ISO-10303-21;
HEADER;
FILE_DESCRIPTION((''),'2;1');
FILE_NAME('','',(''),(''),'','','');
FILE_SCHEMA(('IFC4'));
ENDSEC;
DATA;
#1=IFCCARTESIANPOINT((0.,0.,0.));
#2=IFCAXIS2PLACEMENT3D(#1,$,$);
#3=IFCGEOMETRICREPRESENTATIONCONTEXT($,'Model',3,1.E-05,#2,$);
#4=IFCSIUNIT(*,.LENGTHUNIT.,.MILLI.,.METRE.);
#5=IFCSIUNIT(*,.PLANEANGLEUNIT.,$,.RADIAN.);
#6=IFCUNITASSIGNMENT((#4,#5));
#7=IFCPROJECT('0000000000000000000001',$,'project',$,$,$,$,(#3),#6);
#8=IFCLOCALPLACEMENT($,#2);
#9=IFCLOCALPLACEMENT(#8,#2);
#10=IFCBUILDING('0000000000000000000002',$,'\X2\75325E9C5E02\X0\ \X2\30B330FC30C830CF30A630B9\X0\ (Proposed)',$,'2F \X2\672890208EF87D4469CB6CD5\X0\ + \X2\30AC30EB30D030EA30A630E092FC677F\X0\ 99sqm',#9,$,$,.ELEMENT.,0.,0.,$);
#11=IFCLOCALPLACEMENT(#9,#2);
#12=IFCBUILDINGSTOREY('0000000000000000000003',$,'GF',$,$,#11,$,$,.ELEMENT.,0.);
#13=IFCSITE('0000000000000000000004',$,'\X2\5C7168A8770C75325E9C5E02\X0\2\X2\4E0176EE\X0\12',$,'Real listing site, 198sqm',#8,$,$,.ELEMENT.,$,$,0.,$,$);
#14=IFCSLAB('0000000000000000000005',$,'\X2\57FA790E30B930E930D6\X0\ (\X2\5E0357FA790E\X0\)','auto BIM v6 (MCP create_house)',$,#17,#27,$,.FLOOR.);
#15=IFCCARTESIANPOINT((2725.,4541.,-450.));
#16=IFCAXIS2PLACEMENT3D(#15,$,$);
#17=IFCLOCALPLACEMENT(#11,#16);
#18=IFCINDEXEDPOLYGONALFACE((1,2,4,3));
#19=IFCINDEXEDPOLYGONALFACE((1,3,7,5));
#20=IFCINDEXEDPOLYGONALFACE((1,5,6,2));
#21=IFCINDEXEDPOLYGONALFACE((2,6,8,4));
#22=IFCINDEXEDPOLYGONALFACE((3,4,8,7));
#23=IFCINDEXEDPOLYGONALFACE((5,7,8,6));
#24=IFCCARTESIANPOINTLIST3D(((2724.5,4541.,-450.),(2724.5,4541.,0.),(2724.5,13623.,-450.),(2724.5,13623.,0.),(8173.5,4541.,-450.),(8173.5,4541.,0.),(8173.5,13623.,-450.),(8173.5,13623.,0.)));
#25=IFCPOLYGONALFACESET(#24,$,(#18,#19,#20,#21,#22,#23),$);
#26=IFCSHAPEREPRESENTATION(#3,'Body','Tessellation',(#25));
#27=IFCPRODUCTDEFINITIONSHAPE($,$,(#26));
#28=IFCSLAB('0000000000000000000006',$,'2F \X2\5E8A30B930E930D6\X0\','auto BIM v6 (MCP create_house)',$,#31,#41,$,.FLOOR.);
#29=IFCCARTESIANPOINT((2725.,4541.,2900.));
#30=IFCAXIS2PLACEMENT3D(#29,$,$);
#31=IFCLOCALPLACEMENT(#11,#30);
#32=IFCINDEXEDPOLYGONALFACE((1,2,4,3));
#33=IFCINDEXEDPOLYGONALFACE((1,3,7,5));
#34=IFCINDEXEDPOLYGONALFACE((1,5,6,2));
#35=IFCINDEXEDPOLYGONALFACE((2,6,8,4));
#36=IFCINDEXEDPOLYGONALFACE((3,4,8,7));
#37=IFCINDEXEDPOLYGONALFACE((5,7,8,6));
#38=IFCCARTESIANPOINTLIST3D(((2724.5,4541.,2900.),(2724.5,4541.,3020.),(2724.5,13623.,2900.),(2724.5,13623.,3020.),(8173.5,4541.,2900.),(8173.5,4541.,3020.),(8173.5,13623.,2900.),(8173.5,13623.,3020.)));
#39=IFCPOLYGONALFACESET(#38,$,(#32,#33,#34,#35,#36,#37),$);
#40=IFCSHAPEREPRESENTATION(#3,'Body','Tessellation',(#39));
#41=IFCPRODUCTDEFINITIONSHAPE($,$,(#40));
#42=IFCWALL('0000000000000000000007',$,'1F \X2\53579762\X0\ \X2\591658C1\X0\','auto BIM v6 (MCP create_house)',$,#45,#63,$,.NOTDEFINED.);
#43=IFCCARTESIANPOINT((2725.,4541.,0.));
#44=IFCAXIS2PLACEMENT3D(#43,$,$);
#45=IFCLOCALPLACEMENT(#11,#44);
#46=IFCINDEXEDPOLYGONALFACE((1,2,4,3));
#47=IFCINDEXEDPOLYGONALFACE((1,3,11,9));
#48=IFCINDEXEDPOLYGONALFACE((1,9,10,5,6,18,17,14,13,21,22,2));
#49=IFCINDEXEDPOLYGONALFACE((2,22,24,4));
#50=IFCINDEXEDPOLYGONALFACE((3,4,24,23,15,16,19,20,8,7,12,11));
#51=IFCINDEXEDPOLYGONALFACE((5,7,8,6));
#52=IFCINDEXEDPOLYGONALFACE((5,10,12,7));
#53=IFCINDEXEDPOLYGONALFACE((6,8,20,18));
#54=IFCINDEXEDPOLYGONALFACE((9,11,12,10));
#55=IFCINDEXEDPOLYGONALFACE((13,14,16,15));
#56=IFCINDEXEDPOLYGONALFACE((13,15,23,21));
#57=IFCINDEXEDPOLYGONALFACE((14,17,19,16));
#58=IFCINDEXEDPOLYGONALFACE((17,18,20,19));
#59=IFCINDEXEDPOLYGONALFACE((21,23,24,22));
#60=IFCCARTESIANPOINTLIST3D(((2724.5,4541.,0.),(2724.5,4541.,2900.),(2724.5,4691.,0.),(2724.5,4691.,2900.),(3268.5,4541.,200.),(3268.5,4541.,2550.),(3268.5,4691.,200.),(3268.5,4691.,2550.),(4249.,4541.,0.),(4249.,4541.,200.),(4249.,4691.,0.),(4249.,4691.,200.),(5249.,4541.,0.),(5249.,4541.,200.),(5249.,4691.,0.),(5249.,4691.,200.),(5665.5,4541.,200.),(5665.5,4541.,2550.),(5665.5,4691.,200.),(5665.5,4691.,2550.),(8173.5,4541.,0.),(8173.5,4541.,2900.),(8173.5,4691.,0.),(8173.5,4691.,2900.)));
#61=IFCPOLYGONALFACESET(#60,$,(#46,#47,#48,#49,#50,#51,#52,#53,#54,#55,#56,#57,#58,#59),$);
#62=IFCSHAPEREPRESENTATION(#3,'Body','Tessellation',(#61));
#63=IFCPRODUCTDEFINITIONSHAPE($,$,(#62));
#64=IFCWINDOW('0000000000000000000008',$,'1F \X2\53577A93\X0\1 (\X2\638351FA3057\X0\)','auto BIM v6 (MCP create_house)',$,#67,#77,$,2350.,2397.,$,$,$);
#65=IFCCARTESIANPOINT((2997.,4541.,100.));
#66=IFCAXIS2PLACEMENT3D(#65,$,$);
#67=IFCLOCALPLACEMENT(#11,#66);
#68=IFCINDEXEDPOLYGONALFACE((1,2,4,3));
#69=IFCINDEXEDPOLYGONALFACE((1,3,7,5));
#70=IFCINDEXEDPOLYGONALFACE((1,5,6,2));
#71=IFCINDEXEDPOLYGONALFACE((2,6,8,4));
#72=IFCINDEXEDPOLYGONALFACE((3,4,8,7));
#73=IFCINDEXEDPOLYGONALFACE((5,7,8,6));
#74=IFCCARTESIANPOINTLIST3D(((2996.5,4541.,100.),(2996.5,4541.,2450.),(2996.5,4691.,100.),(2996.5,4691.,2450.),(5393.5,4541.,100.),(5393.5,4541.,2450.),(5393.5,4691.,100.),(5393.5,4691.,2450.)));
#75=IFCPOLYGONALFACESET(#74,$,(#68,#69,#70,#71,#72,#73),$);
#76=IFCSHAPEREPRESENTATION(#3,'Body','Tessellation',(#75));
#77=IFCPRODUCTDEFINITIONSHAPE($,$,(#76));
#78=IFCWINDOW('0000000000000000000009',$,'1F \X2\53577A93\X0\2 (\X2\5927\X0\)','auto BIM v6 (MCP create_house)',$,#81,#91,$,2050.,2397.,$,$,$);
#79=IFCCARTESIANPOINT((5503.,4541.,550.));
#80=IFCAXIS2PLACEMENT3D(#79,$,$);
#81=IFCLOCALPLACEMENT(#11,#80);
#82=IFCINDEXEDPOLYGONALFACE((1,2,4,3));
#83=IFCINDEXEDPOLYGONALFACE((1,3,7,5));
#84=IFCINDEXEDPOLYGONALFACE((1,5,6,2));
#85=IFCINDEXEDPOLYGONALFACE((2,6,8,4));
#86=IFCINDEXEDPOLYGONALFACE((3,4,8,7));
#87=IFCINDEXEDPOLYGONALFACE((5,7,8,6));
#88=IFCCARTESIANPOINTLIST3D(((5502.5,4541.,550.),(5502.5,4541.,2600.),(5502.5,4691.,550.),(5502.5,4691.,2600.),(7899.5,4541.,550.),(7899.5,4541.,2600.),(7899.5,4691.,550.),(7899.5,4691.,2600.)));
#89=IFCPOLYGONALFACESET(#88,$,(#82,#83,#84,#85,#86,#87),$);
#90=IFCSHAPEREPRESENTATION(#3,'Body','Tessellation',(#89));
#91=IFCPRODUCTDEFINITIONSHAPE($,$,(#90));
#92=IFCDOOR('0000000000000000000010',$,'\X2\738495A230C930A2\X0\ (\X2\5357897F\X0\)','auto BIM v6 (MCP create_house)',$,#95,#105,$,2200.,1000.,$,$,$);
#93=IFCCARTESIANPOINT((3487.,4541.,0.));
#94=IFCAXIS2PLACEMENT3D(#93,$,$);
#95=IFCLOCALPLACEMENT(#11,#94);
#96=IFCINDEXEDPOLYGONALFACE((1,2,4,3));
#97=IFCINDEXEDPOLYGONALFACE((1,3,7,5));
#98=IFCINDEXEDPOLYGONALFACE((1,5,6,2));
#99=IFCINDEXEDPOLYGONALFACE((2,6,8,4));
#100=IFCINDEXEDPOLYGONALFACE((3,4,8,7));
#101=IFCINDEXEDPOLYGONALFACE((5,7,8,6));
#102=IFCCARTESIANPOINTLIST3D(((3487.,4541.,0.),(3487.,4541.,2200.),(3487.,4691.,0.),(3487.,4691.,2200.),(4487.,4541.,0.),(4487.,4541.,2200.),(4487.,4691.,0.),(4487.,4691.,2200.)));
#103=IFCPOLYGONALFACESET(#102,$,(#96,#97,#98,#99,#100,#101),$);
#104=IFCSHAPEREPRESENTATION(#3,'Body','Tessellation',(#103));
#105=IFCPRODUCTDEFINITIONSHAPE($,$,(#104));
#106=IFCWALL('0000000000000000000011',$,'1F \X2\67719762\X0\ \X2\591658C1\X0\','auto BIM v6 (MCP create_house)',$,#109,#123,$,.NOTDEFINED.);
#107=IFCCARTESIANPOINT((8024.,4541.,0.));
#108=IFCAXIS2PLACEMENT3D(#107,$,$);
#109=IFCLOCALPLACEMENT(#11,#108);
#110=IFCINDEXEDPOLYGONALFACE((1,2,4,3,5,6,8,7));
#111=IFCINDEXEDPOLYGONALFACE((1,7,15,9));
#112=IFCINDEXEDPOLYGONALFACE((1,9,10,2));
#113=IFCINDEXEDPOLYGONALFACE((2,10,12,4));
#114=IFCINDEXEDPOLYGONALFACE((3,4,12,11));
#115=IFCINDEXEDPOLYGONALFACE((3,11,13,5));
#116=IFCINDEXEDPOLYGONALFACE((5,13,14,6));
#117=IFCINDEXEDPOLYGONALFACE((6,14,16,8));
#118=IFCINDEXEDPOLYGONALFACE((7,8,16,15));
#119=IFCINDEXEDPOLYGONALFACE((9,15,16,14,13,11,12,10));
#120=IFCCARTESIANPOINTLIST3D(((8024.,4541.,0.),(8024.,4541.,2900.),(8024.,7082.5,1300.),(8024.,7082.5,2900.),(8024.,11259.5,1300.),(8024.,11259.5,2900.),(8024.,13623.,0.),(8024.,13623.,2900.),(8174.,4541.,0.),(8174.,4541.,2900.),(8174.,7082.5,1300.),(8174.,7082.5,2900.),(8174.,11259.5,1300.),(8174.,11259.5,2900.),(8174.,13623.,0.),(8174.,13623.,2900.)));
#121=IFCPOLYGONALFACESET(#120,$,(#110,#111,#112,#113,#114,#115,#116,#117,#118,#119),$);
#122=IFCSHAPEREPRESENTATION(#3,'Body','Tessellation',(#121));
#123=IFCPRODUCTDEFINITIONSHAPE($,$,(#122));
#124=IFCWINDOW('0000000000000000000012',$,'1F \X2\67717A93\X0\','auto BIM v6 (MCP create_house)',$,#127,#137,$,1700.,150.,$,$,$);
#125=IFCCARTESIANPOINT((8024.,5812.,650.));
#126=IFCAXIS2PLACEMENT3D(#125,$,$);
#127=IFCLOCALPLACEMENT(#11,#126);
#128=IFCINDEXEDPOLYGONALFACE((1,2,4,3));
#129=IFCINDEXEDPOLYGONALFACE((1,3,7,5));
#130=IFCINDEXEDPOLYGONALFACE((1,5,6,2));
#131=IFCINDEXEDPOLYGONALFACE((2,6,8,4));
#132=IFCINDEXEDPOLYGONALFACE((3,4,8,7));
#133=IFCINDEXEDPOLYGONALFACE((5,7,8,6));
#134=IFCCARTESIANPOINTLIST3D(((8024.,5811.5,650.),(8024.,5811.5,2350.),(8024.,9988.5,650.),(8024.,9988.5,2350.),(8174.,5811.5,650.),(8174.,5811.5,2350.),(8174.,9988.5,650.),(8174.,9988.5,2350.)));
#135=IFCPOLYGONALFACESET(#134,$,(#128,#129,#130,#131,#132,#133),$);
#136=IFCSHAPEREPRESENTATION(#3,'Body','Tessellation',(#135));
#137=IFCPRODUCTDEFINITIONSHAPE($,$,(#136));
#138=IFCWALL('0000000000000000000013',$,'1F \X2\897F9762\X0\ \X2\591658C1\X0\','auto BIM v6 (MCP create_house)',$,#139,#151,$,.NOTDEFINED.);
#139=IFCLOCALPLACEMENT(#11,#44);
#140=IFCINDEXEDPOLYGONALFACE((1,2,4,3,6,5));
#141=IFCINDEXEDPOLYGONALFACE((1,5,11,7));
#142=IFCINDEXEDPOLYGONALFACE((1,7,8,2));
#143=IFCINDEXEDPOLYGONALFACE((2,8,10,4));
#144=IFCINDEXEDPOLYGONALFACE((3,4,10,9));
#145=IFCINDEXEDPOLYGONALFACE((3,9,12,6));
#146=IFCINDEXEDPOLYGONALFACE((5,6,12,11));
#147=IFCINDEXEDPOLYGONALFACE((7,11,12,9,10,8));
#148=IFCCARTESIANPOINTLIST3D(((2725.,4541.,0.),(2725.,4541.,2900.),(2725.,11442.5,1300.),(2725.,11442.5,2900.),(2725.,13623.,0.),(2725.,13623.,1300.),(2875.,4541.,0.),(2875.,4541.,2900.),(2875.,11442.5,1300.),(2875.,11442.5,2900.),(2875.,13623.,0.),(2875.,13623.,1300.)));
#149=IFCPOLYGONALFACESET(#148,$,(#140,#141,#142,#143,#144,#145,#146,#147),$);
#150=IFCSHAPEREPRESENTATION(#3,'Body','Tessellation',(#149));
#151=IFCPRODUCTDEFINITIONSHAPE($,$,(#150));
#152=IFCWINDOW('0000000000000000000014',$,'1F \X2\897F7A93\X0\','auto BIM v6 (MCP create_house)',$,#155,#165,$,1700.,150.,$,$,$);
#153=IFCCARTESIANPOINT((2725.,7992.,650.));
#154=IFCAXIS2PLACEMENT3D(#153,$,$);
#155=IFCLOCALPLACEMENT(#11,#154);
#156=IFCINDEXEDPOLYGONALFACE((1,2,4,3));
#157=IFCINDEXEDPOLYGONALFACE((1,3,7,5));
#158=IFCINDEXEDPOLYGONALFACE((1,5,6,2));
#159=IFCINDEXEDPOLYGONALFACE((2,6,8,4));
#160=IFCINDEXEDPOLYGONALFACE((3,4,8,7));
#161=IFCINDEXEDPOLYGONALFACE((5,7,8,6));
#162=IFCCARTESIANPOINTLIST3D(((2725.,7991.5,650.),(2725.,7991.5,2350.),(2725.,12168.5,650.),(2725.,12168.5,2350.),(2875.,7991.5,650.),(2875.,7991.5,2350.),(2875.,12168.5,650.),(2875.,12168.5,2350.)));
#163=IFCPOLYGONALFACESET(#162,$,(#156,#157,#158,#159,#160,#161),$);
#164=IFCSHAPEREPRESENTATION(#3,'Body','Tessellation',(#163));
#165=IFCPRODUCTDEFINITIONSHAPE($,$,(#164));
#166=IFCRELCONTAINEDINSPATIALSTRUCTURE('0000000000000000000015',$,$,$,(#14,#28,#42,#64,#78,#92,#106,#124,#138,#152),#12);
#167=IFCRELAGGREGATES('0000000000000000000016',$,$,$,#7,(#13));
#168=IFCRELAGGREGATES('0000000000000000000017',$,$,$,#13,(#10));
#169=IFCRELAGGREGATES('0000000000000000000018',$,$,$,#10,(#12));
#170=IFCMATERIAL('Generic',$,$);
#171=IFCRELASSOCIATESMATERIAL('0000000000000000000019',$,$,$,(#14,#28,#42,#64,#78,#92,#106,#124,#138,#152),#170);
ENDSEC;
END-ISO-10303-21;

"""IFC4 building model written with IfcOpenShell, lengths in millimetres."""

from ifc_helpers import new_model, si_unit, frame, frame_2d, origin, place, context, project, spatial, rectangle, extrude, material, element, fill, save


model = new_model("IFC4")

# Units and contexts
model_context = context("Model", 3, precision=1e-05, world=origin())
ifc_project = project(units=[si_unit("LENGTHUNIT", "METRE", prefix="MILLI"), si_unit("PLANEANGLEUNIT", "RADIAN")], contexts=[model_context])

# Site, building, storey
site_placement = place(None, origin())
site = spatial("IfcSite", under=ifc_project, at=site_placement, Name="山梨県甲府市2丁目12", ObjectType="Real listing site, 198sqm", CompositionType="ELEMENT", RefElevation=0.0)
building_placement = place(site_placement, origin())
building = spatial("IfcBuilding", under=site, at=building_placement, Name="甲府市 コートハウス (Proposed)", ObjectType="2F 木造軸組構法 + ガルバリウム鋼板 99sqm", CompositionType="ELEMENT", ElevationOfRefHeight=0.0, ElevationOfTerrain=0.0)
storey_placement = place(building_placement, origin())
storey = spatial("IfcBuildingStorey", under=building, at=storey_placement, Name="GF", CompositionType="ELEMENT", Elevation=0.0)

# Slabs
ifc_material = material(Name="Generic")
slab_1_placement = place(storey_placement, frame((2725.0, 4541.0, -450.0)))
element("IfcSlab", 1, at=slab_1_placement, inside=storey, material=ifc_material, Name="基礎スラブ (布基礎)", Description="auto BIM v6 (MCP create_house)", PredefinedType="FLOOR", context=model_context, shape_type="SweptSolid", body=[
    extrude(rectangle(XDim=5449.0, YDim=9082.0, at=frame_2d((2724.0, 4541.0))), frame((2725.0, 4541.0, -450.0)), (0.0, 0.0, 1.0), 450.0),
])
slab_2_placement = place(storey_placement, frame((2725.0, 4541.0, 2900.0)))
element("IfcSlab", 2, at=slab_2_placement, inside=storey, material=ifc_material, Name="2F 床スラブ", Description="auto BIM v6 (MCP create_house)", PredefinedType="FLOOR", context=model_context, shape_type="SweptSolid", body=[
    extrude(rectangle(XDim=5449.0, YDim=9082.0, at=frame_2d((2724.0, 4541.0))), frame((2725.0, 4541.0, 2900.0)), (0.0, 0.0, 1.0), 120.0),
])

# Wall, openings, windows, door
wall_1_placement = place(storey_placement, frame((2725.0, 4541.0, 0.0)))
wall_1 = element("IfcWall", 3, at=wall_1_placement, inside=storey, material=ifc_material, Name="1F 南面 外壁", Description="auto BIM v6 (MCP create_house)", PredefinedType="NOTDEFINED", context=model_context, shape_type="SweptSolid", body=[
    extrude(rectangle(XDim=5449.0, YDim=150.0, at=frame_2d((2724.0, 75.0))), frame((2725.0, 4541.0, 0.0)), (0.0, 0.0, 1.0), 2900.0),
])
opening_1_placement = place(storey_placement, frame((2997.0, 4541.0, 100.0)))
opening_1 = element("IfcOpeningElement", 4, at=opening_1_placement, cuts=wall_1, PredefinedType="NOTDEFINED", context=model_context, shape_type="SweptSolid", body=[
    extrude(rectangle(XDim=2397.0, YDim=150.0, at=frame_2d((1198.0, 75.0))), frame((2997.0, 4541.0, 100.0)), (0.0, 0.0, 1.0), 2350.0),
])
opening_2_placement = place(storey_placement, frame((5503.0, 4541.0, 550.0)))
opening_2 = element("IfcOpeningElement", 5, at=opening_2_placement, cuts=wall_1, PredefinedType="NOTDEFINED", context=model_context, shape_type="SweptSolid", body=[
    extrude(rectangle(XDim=2397.0, YDim=150.0, at=frame_2d((1198.0, 75.0))), frame((5503.0, 4541.0, 550.0)), (0.0, 0.0, 1.0), 2050.0),
])
opening_3_placement = place(storey_placement, frame((3487.0, 4541.0, 0.0)))
opening_3 = element("IfcOpeningElement", 6, at=opening_3_placement, cuts=wall_1, PredefinedType="NOTDEFINED", context=model_context, shape_type="SweptSolid", body=[
    extrude(rectangle(XDim=1000.0, YDim=150.0, at=frame_2d((500.0, 75.0))), frame((3487.0, 4541.0, 0.0)), (0.0, 0.0, 1.0), 2200.0),
])
window_1_placement = place(storey_placement, frame((2997.0, 4541.0, 100.0)))
window_1 = element("IfcWindow", 7, at=window_1_placement, inside=storey, material=ifc_material, Name="1F 南窓1 (掃出し)", Description="auto BIM v6 (MCP create_house)", OverallHeight=2350.0, OverallWidth=2397.0, context=model_context, shape_type="SweptSolid", body=[
    extrude(rectangle(XDim=2397.0, YDim=150.0, at=frame_2d((1198.0, 75.0))), frame((2997.0, 4541.0, 100.0)), (0.0, 0.0, 1.0), 2350.0),
])
fill(opening_1, window_1)
window_2_placement = place(storey_placement, frame((5503.0, 4541.0, 550.0)))
window_2 = element("IfcWindow", 8, at=window_2_placement, inside=storey, material=ifc_material, Name="1F 南窓2 (大)", Description="auto BIM v6 (MCP create_house)", OverallHeight=2050.0, OverallWidth=2397.0, context=model_context, shape_type="SweptSolid", body=[
    extrude(rectangle(XDim=2397.0, YDim=150.0, at=frame_2d((1198.0, 75.0))), frame((5503.0, 4541.0, 550.0)), (0.0, 0.0, 1.0), 2050.0),
])
fill(opening_2, window_2)
door_placement = place(storey_placement, frame((3487.0, 4541.0, 0.0)))
door = element("IfcDoor", 9, at=door_placement, inside=storey, material=ifc_material, Name="玄関ドア (南西)", Description="auto BIM v6 (MCP create_house)", OverallHeight=2200.0, OverallWidth=1000.0, context=model_context, shape_type="SweptSolid", body=[
    extrude(rectangle(XDim=1000.0, YDim=150.0, at=frame_2d((500.0, 75.0))), frame((3487.0, 4541.0, 0.0)), (0.0, 0.0, 1.0), 2200.0),
])
fill(opening_3, door)

# Walls, openings, windows
wall_2_placement = place(storey_placement, frame((8024.0, 4541.0, 0.0)))
wall_2 = element("IfcWall", 10, at=wall_2_placement, inside=storey, material=ifc_material, Name="1F 東面 外壁", Description="auto BIM v6 (MCP create_house)", PredefinedType="NOTDEFINED", context=model_context, shape_type="SweptSolid", body=[
    extrude(rectangle(XDim=150.0, YDim=9082.0, at=frame_2d((75.0, 4541.0))), frame((8024.0, 4541.0, 0.0)), (0.0, 0.0, 1.0), 2900.0),
])
opening_4_placement = place(storey_placement, frame((8024.0, 5812.0, 650.0)))
opening_4 = element("IfcOpeningElement", 11, at=opening_4_placement, cuts=wall_2, PredefinedType="NOTDEFINED", context=model_context, shape_type="SweptSolid", body=[
    extrude(rectangle(XDim=150.0, YDim=4177.0, at=frame_2d((75.0, 2088.0))), frame((8024.0, 5812.0, 650.0)), (0.0, 0.0, 1.0), 1700.0),
])
window_3_placement = place(storey_placement, frame((8024.0, 5812.0, 650.0)))
window_3 = element("IfcWindow", 12, at=window_3_placement, inside=storey, material=ifc_material, Name="1F 東窓", Description="auto BIM v6 (MCP create_house)", OverallHeight=1700.0, OverallWidth=150.0, context=model_context, shape_type="SweptSolid", body=[
    extrude(rectangle(XDim=150.0, YDim=4177.0, at=frame_2d((75.0, 2088.0))), frame((8024.0, 5812.0, 650.0)), (0.0, 0.0, 1.0), 1700.0),
])
fill(opening_4, window_3)
wall_3_placement = place(storey_placement, frame((2725.0, 4541.0, 0.0)))
wall_3 = element("IfcWall", 13, at=wall_3_placement, inside=storey, material=ifc_material, Name="1F 西面 外壁", Description="auto BIM v6 (MCP create_house)", PredefinedType="NOTDEFINED", context=model_context, shape_type="SweptSolid", body=[
    extrude(rectangle(XDim=150.0, YDim=9082.0, at=frame_2d((75.0, 4541.0))), frame((2725.0, 4541.0, 0.0)), (0.0, 0.0, 1.0), 2900.0),
])
opening_5_placement = place(storey_placement, frame((2725.0, 7992.0, 650.0)))
opening_5 = element("IfcOpeningElement", 14, at=opening_5_placement, cuts=wall_3, PredefinedType="NOTDEFINED", context=model_context, shape_type="SweptSolid", body=[
    extrude(rectangle(XDim=150.0, YDim=4177.0, at=frame_2d((75.0, 2088.0))), frame((2725.0, 7992.0, 650.0)), (0.0, 0.0, 1.0), 1700.0),
])
window_4_placement = place(storey_placement, frame((2725.0, 7992.0, 650.0)))
window_4 = element("IfcWindow", 15, at=window_4_placement, inside=storey, material=ifc_material, Name="1F 西窓", Description="auto BIM v6 (MCP create_house)", OverallHeight=1700.0, OverallWidth=150.0, context=model_context, shape_type="SweptSolid", body=[
    extrude(rectangle(XDim=150.0, YDim=4177.0, at=frame_2d((75.0, 2088.0))), frame((2725.0, 7992.0, 650.0)), (0.0, 0.0, 1.0), 1700.0),
])
fill(opening_5, window_4)

save(model, "model.ifc")
